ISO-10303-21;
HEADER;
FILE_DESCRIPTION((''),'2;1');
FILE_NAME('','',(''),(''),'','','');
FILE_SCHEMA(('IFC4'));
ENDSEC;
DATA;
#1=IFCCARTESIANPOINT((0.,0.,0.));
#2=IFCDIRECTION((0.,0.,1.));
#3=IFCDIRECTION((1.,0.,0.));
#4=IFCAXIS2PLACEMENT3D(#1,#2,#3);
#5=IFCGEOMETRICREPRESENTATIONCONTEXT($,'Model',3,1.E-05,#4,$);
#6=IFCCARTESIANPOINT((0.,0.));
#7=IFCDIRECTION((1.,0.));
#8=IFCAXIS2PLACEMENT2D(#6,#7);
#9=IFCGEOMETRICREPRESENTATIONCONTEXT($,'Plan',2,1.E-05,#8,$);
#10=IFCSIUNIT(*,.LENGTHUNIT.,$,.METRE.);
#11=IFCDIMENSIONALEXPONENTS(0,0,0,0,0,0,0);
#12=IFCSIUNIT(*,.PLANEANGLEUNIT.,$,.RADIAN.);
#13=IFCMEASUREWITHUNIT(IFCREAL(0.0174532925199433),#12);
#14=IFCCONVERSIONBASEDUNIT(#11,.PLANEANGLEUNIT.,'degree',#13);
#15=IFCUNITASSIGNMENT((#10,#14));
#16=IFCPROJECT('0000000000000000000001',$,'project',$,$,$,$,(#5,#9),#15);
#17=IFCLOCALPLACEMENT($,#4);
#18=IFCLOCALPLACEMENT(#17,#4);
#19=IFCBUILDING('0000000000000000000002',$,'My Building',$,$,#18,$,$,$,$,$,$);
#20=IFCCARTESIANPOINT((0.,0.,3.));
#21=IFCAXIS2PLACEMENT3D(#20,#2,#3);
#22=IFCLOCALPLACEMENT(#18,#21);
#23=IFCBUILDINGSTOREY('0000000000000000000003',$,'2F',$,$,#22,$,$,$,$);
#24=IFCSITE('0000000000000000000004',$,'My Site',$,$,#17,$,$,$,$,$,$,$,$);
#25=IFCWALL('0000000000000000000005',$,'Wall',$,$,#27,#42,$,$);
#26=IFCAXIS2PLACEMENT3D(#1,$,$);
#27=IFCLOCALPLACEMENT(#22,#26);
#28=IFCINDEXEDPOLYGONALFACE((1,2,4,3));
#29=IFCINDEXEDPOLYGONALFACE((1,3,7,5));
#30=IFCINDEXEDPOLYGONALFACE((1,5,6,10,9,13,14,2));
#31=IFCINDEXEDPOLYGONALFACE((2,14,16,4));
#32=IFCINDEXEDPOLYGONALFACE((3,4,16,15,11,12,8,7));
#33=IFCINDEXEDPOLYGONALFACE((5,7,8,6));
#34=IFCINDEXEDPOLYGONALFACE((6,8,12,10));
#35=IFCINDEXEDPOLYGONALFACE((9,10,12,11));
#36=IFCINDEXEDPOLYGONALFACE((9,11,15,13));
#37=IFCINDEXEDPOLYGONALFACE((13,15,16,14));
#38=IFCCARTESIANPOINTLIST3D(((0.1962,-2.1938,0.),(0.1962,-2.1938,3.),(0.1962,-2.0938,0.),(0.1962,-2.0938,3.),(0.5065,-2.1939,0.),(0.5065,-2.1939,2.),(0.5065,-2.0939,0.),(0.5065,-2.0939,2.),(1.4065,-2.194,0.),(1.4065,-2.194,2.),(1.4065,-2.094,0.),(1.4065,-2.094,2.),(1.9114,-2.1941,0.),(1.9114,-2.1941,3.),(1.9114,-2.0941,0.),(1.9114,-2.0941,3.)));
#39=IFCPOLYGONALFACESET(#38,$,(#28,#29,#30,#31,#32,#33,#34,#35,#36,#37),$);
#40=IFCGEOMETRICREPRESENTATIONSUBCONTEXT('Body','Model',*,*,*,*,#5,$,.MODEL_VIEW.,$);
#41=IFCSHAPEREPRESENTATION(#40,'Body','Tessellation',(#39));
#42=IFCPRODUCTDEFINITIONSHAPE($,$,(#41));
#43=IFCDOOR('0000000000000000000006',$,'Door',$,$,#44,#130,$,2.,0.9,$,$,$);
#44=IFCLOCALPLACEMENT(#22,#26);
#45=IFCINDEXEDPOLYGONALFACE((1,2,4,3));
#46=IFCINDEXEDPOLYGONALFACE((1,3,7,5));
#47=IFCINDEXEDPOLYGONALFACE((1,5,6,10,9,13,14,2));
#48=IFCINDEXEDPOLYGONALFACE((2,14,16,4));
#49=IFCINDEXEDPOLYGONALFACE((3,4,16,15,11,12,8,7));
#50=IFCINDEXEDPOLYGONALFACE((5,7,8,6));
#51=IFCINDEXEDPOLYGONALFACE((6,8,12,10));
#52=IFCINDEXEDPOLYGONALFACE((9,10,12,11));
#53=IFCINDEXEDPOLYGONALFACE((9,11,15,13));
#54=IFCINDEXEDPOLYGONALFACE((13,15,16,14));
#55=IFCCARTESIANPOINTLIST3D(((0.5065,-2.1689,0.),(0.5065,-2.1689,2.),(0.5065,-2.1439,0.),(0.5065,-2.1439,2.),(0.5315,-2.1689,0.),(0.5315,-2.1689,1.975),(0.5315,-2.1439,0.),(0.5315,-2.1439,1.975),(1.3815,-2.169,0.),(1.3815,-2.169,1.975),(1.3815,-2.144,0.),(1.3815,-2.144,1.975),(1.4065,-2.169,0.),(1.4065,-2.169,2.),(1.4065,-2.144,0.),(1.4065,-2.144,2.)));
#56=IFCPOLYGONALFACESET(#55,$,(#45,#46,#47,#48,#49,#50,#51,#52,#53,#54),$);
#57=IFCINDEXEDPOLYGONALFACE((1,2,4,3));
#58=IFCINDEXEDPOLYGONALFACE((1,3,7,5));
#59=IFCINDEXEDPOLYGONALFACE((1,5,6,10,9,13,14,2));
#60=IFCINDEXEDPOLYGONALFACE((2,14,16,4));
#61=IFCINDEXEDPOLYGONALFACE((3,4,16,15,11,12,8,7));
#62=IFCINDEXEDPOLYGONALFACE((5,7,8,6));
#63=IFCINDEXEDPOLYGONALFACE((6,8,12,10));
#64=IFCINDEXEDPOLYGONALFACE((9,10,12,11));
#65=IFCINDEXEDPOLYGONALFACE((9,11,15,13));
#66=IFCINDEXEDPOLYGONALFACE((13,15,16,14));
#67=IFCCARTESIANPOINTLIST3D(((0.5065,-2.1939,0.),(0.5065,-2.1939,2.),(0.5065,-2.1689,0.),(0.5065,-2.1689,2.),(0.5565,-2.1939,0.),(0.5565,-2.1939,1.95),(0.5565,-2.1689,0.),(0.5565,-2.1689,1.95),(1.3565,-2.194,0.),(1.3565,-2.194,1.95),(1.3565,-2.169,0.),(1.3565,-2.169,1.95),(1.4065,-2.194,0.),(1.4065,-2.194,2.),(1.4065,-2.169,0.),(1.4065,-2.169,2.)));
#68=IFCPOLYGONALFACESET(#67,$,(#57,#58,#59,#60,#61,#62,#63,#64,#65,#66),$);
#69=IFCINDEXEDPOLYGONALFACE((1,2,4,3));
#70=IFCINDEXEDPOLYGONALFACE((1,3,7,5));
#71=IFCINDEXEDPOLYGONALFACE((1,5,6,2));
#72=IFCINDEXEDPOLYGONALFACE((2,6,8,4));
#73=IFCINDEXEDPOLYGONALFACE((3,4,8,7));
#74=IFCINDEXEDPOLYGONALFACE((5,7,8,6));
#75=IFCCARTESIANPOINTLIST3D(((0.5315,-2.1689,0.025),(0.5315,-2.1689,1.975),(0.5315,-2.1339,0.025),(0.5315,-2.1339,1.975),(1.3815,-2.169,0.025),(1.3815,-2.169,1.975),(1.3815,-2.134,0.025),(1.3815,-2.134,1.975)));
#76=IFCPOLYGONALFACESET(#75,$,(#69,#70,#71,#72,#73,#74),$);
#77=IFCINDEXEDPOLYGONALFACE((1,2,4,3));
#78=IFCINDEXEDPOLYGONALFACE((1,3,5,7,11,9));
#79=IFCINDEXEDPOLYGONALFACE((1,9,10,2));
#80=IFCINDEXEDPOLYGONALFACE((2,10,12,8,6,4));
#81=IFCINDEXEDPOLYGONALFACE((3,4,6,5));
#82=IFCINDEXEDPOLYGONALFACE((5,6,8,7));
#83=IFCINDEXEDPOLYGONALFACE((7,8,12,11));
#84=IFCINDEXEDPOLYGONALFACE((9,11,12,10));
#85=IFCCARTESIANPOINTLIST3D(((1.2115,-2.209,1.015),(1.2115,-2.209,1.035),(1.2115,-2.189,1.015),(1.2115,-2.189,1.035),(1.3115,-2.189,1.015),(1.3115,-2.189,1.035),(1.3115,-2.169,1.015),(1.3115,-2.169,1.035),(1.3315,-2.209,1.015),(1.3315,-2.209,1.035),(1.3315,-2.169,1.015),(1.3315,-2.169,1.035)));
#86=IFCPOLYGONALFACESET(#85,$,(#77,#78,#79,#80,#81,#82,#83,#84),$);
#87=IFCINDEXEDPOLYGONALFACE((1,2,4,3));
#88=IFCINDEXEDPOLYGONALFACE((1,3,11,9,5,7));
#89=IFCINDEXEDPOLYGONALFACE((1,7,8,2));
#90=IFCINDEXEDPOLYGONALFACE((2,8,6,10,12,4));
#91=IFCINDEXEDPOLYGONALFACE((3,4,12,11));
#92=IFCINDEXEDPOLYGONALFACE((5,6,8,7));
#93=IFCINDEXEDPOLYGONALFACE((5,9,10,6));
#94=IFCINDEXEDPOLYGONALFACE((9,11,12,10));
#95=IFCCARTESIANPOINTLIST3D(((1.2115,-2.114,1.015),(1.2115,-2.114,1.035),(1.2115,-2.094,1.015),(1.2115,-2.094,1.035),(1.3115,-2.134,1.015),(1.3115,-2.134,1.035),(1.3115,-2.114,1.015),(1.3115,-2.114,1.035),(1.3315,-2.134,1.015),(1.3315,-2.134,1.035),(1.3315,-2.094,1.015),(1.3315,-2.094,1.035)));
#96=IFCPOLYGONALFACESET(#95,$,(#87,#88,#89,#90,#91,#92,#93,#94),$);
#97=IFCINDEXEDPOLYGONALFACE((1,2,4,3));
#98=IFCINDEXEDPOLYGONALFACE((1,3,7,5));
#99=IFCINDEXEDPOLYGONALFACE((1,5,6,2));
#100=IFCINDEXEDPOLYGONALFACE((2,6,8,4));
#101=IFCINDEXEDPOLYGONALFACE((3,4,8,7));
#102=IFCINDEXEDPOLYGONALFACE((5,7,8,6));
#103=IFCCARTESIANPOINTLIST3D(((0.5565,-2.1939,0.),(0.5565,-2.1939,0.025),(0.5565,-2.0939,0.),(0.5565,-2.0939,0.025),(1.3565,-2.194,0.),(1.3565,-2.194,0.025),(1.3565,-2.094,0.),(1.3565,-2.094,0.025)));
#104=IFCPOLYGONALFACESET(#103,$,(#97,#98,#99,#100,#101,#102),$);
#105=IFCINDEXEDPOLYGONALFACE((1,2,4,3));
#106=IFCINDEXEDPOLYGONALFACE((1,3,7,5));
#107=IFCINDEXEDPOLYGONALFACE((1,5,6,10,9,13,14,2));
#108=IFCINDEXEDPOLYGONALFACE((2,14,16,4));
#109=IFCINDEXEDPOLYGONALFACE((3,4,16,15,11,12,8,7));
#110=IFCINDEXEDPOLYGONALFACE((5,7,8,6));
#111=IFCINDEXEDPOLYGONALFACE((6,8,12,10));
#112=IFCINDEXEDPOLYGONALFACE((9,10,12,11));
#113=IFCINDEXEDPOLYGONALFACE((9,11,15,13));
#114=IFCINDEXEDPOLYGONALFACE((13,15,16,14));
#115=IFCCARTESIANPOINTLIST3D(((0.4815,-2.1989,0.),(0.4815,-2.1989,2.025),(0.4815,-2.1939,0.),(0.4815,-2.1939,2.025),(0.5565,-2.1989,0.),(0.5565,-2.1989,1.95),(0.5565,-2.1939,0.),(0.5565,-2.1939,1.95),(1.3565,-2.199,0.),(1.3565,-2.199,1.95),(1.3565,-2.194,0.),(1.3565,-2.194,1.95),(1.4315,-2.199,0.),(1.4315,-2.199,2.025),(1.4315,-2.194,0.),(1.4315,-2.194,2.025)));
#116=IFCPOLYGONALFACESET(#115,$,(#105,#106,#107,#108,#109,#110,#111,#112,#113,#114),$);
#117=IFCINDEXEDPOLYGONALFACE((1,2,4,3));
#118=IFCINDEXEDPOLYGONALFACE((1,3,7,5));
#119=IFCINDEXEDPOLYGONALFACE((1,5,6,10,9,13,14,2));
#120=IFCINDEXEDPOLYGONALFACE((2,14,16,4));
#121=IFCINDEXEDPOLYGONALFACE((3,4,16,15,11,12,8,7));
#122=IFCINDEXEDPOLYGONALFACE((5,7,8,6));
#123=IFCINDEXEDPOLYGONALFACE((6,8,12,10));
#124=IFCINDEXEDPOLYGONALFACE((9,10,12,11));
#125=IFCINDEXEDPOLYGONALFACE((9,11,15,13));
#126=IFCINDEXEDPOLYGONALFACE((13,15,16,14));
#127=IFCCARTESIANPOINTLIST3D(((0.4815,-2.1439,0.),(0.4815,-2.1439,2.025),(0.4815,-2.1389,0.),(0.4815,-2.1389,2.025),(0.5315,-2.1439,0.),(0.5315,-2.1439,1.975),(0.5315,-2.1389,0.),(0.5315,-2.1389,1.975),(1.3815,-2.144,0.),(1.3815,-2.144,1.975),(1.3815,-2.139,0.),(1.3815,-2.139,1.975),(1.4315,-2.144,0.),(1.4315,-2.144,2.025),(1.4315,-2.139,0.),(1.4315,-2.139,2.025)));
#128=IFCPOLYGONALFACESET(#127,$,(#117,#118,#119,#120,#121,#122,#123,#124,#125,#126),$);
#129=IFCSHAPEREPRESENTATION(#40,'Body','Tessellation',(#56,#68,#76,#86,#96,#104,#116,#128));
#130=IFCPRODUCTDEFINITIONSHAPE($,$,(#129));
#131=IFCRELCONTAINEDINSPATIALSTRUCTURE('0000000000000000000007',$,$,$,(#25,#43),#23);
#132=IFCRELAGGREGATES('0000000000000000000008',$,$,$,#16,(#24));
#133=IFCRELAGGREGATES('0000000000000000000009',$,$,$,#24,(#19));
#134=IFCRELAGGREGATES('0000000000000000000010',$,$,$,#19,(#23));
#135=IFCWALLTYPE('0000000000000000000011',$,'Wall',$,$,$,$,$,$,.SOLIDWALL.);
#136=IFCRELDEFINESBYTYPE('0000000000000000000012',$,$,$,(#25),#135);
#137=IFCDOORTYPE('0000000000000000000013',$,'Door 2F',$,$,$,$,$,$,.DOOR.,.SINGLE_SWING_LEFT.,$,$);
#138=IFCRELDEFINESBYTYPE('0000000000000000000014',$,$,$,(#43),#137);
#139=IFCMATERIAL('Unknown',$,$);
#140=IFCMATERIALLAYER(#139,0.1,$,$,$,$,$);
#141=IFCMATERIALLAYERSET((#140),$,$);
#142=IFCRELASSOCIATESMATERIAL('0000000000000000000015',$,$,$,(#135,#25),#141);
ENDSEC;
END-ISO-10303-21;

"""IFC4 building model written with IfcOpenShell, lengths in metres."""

from ifc_helpers import new_model, entity, si_unit, converted_unit, frame, origin_with_axes, origin_2d_with_axis, place, context, subcontext, project, spatial, line, indexed_curve, outline, extrude, shape, source, transform, mapped, material, layer, layer_set, layer_usage, type_object, type_shapes, element, fill, save


model = new_model("IFC4")

# Units and contexts
model_context = context("Model", 3, precision=1e-05, world=origin_with_axes())
plan_context = context("Plan", 2, precision=1e-05, world=origin_2d_with_axis())
body_context_1 = subcontext(model_context, "Body", "Model", "MODEL_VIEW")
body_context_2 = subcontext(plan_context, "Body", "Plan", "PLAN_VIEW")
ifc_project = project(units=[si_unit("LENGTHUNIT", "METRE"), converted_unit("PLANEANGLEUNIT", "degree", entity("IfcReal", 0.0174532925199433), si_unit("PLANEANGLEUNIT", "RADIAN"), dimensions=[0, 0, 0, 0, 0, 0, 0])], contexts=[model_context, plan_context])

# Site, building, storey
site_placement = place(None, origin_with_axes())
site = spatial("IfcSite", under=ifc_project, at=site_placement, Name="My Site")
building_placement = place(site_placement, origin_with_axes())
building = spatial("IfcBuilding", under=site, at=building_placement, Name="My Building")
storey_placement = place(building_placement, frame((0.0, 0.0, 3.0), z_axis=(0.0, 0.0, 1.0), x_axis=(1.0, 0.0, 0.0)))
storey = spatial("IfcBuildingStorey", under=building, at=storey_placement, Name="2F")

# Shared definitions
ifc_material = material(Name="Unknown")

# Shared definitions
ifc_layer_1 = layer(ifc_material, 0.1)
ifc_layer_set_1 = layer_set([ifc_layer_1])
wall_type = type_object("IfcWallType", Name="Wall", PredefinedType="SOLIDWALL", material=ifc_layer_set_1)

# Shared definitions
shared_shape_1 = source(origin_with_axes(), body_context_1, "Body", "SweptSolid", [
    extrude(outline(indexed_curve([(0.0, 0.0), (0.9, 0.0), (0.9, 2.0), (0.0, 2.0)], segments=[line(1, 2, 3, 4, 1)])), frame((0.0, -0.6, 0.0), z_axis=(0.0, -1.0, 0.0), x_axis=(1.0, 0.0, 0.0)), (0.0, 0.0, -1.0), 1.2),
])
door_type_1 = type_object("IfcDoorType", Name="Door 2F", OperationType="SINGLE_SWING_LEFT", PredefinedType="DOOR")
shared_shape_2 = source(origin_with_axes(), body_context_1, "Body", "SweptSolid", [
    extrude(outline(indexed_curve([(0.0, 0.0), (0.0, 2.0), (0.9, 2.0), (0.9, 0.0), (0.875, 0.0), (0.875, 1.975), (0.025, 1.975), (0.025, 0.0)], segments=[line(1, 2, 3, 4, 5, 6, 7, 8, 1)])), frame((0.0, 0.025, 0.0), z_axis=(0.0, -1.0, 0.0), x_axis=(1.0, 0.0, 0.0)), (0.0, 0.0, -1.0), 0.025),
    extrude(outline(indexed_curve([(0.0, 0.0), (0.0, 2.0), (0.9, 2.0), (0.9, 0.0), (0.85, 0.0), (0.85, 1.95), (0.05, 1.95), (0.05, 0.0)], segments=[line(1, 2, 3, 4, 5, 6, 7, 8, 1)])), frame((0.0, 0.0, 0.0), z_axis=(0.0, -1.0, 0.0), x_axis=(1.0, 0.0, 0.0)), (0.0, 0.0, -1.0), 0.025),
    extrude(outline(indexed_curve([(0.0, 0.0), (0.85, 0.0), (0.85, 0.035), (0.0, 0.035)], segments=[line(1, 2, 3, 4, 1)])), frame((0.025, 0.025, 0.025), z_axis=(0.0, 0.0, 1.0), x_axis=(1.0, 0.0, 0.0)), (0.0, 0.0, 1.0), 1.95),
    extrude(outline(indexed_curve([(0.0, 0.0), (0.0, -0.04), (-0.12, -0.04), (-0.12, -0.02), (-0.02, -0.02), (-0.02, 0.0)], segments=[line(1, 2, 3, 4, 5, 6, 1)])), frame((0.825, 0.025, 1.015), z_axis=(0.0, 0.0, 1.0), x_axis=(1.0, 0.0, 0.0)), (0.0, 0.0, 1.0), 0.02),
    extrude(outline(indexed_curve([(0.0, 0.0), (0.0, 0.04), (-0.12, 0.04), (-0.12, 0.02), (-0.02, 0.02), (-0.02, 0.0)], segments=[line(1, 2, 3, 4, 5, 6, 1)])), frame((0.825, 0.06, 1.015), z_axis=(0.0, 0.0, 1.0), x_axis=(1.0, 0.0, 0.0)), (0.0, 0.0, 1.0), 0.02),
    extrude(outline(indexed_curve([(0.0, 0.0), (0.8, 0.0), (0.8, 0.1), (0.0, 0.1)], segments=[line(1, 2, 3, 4, 1)])), frame((0.05, 0.0, 0.0), z_axis=(0.0, 0.0, 1.0), x_axis=(1.0, 0.0, 0.0)), (0.0, 0.0, 1.0), 0.025),
    extrude(outline(indexed_curve([(0.0, 0.0), (0.0, 2.025), (0.95, 2.025), (0.95, 0.0), (0.875, 0.0), (0.875, 1.95), (0.075, 1.95), (0.075, 0.0)], segments=[line(1, 2, 3, 4, 5, 6, 7, 8, 1)])), frame((-0.025, -0.005, 0.0), z_axis=(0.0, -1.0, 0.0), x_axis=(1.0, 0.0, 0.0)), (0.0, 0.0, -1.0), 0.005),
    extrude(outline(indexed_curve([(0.0, 0.0), (0.0, 2.025), (0.95, 2.025), (0.95, 0.0), (0.9, 0.0), (0.9, 1.975), (0.05, 1.975), (0.05, 0.0)], segments=[line(1, 2, 3, 4, 5, 6, 7, 8, 1)])), frame((-0.025, 0.05, 0.0), z_axis=(0.0, -1.0, 0.0), x_axis=(1.0, 0.0, 0.0)), (0.0, 0.0, -1.0), 0.005),
])
shared_shape_3 = source(origin_with_axes(), body_context_2, "Body", "Curve2D", [
    entity("IfcIndexedPolyCurve", entity("IfcCartesianPointList2D", [[0.0, 0.0], [0.0, 0.05], [0.025, 0.05], [0.025, 0.025], [0.05, 0.025], [0.05, 0.0]]), [entity("IfcLineIndex", [1, 2, 3, 4, 5, 6, 1])]),
    entity("IfcIndexedPolyCurve", entity("IfcCartesianPointList2D", [[0.9, 0.0], [0.9, 0.05], [0.875, 0.05], [0.875, 0.025], [0.85, 0.025], [0.85, 0.0]]), [entity("IfcLineIndex", [1, 2, 3, 4, 5, 6, 1])]),
    entity("IfcTrimmedCurve", entity("IfcEllipse", entity("IfcAxis2Placement2D", entity("IfcCartesianPoint", [0.06, 0.05]), entity("IfcDirection", [1.0, 0.0])), 0.815, 0.85), [entity("IfcCartesianPoint", [0.875, 0.05])], [entity("IfcCartesianPoint", [0.06, 0.9])], True, "CARTESIAN"),
    entity("IfcIndexedPolyCurve", entity("IfcCartesianPointList2D", [[0.025, 0.05], [0.06, 0.05], [0.06, 0.9], [0.025, 0.9]]), [entity("IfcLineIndex", [1, 2, 3, 4, 1])]),
])
type_shapes(door_type_1, [shared_shape_2, shared_shape_3])

# Wall, opening, door
ifc_layer_usage_1 = layer_usage(ifc_layer_set_1, "AXIS2", "POSITIVE", 0.0)
wall_1_placement = place(storey_placement, frame((0.1962, -2.1938, 0.0), z_axis=(0.0, 0.0, 1.0), x_axis=(1.0, -0.00013, 0.0)))
wall_1 = element("IfcWall", 1, at=wall_1_placement, inside=storey, type_object=wall_type, material=ifc_layer_usage_1, Name="Wall", context=body_context_1, shape_type="SweptSolid", body=[
    extrude(outline(indexed_curve([(0.0, 0.0), (0.0, 0.1), (1.7152, 0.1), (1.7152, 0.0)], segments=[line(1, 2, 3, 4, 1)])), origin_with_axes(), (0.0, 0.0, 1.0), 3.0),
])
opening_1_placement = place(wall_1_placement, frame((0.3103, 0.0, 0.0), z_axis=(0.0, 0.0, 1.0), x_axis=(1.0, 0.0, 0.0)))
opening_1 = element("IfcOpeningElement", 2, at=opening_1_placement, cuts=wall_1, PredefinedType="OPENING", context=body_context_1, shape_type="MappedRepresentation", body=[
    mapped(shared_shape_1, transform((0.0, 0.0, 0.0), x_axis=(1.0, 0.0, 0.0), y_axis=(0.0, 1.0, 0.0), z_axis=(0.0, 0.0, 1.0), scale=1.0)),
])
door_1_placement = place(opening_1_placement, frame((0.0, 0.0, 0.0), z_axis=(0.0, 0.0, 1.0), x_axis=(1.0, 0.0, 0.0)))
door_1 = element("IfcDoor", 3, at=door_1_placement, inside=storey, type_object=door_type_1, Name="Door", OverallHeight=2.0, OverallWidth=0.9, shapes=[
    shape(body_context_1, "Body", "MappedRepresentation", [mapped(shared_shape_2, transform((0.0, 0.0, 0.0), x_axis=(1.0, 0.0, 0.0), y_axis=(0.0, 1.0, 0.0), z_axis=(0.0, 0.0, 1.0), scale=1.0))]),
    shape(body_context_2, "Body", "MappedRepresentation", [mapped(shared_shape_3, transform((0.0, 0.0, 0.0), x_axis=(1.0, 0.0, 0.0), y_axis=(0.0, 1.0, 0.0), z_axis=(0.0, 0.0, 1.0), scale=1.0))]),
])
fill(opening_1, door_1)

save(model, "model.ifc")
